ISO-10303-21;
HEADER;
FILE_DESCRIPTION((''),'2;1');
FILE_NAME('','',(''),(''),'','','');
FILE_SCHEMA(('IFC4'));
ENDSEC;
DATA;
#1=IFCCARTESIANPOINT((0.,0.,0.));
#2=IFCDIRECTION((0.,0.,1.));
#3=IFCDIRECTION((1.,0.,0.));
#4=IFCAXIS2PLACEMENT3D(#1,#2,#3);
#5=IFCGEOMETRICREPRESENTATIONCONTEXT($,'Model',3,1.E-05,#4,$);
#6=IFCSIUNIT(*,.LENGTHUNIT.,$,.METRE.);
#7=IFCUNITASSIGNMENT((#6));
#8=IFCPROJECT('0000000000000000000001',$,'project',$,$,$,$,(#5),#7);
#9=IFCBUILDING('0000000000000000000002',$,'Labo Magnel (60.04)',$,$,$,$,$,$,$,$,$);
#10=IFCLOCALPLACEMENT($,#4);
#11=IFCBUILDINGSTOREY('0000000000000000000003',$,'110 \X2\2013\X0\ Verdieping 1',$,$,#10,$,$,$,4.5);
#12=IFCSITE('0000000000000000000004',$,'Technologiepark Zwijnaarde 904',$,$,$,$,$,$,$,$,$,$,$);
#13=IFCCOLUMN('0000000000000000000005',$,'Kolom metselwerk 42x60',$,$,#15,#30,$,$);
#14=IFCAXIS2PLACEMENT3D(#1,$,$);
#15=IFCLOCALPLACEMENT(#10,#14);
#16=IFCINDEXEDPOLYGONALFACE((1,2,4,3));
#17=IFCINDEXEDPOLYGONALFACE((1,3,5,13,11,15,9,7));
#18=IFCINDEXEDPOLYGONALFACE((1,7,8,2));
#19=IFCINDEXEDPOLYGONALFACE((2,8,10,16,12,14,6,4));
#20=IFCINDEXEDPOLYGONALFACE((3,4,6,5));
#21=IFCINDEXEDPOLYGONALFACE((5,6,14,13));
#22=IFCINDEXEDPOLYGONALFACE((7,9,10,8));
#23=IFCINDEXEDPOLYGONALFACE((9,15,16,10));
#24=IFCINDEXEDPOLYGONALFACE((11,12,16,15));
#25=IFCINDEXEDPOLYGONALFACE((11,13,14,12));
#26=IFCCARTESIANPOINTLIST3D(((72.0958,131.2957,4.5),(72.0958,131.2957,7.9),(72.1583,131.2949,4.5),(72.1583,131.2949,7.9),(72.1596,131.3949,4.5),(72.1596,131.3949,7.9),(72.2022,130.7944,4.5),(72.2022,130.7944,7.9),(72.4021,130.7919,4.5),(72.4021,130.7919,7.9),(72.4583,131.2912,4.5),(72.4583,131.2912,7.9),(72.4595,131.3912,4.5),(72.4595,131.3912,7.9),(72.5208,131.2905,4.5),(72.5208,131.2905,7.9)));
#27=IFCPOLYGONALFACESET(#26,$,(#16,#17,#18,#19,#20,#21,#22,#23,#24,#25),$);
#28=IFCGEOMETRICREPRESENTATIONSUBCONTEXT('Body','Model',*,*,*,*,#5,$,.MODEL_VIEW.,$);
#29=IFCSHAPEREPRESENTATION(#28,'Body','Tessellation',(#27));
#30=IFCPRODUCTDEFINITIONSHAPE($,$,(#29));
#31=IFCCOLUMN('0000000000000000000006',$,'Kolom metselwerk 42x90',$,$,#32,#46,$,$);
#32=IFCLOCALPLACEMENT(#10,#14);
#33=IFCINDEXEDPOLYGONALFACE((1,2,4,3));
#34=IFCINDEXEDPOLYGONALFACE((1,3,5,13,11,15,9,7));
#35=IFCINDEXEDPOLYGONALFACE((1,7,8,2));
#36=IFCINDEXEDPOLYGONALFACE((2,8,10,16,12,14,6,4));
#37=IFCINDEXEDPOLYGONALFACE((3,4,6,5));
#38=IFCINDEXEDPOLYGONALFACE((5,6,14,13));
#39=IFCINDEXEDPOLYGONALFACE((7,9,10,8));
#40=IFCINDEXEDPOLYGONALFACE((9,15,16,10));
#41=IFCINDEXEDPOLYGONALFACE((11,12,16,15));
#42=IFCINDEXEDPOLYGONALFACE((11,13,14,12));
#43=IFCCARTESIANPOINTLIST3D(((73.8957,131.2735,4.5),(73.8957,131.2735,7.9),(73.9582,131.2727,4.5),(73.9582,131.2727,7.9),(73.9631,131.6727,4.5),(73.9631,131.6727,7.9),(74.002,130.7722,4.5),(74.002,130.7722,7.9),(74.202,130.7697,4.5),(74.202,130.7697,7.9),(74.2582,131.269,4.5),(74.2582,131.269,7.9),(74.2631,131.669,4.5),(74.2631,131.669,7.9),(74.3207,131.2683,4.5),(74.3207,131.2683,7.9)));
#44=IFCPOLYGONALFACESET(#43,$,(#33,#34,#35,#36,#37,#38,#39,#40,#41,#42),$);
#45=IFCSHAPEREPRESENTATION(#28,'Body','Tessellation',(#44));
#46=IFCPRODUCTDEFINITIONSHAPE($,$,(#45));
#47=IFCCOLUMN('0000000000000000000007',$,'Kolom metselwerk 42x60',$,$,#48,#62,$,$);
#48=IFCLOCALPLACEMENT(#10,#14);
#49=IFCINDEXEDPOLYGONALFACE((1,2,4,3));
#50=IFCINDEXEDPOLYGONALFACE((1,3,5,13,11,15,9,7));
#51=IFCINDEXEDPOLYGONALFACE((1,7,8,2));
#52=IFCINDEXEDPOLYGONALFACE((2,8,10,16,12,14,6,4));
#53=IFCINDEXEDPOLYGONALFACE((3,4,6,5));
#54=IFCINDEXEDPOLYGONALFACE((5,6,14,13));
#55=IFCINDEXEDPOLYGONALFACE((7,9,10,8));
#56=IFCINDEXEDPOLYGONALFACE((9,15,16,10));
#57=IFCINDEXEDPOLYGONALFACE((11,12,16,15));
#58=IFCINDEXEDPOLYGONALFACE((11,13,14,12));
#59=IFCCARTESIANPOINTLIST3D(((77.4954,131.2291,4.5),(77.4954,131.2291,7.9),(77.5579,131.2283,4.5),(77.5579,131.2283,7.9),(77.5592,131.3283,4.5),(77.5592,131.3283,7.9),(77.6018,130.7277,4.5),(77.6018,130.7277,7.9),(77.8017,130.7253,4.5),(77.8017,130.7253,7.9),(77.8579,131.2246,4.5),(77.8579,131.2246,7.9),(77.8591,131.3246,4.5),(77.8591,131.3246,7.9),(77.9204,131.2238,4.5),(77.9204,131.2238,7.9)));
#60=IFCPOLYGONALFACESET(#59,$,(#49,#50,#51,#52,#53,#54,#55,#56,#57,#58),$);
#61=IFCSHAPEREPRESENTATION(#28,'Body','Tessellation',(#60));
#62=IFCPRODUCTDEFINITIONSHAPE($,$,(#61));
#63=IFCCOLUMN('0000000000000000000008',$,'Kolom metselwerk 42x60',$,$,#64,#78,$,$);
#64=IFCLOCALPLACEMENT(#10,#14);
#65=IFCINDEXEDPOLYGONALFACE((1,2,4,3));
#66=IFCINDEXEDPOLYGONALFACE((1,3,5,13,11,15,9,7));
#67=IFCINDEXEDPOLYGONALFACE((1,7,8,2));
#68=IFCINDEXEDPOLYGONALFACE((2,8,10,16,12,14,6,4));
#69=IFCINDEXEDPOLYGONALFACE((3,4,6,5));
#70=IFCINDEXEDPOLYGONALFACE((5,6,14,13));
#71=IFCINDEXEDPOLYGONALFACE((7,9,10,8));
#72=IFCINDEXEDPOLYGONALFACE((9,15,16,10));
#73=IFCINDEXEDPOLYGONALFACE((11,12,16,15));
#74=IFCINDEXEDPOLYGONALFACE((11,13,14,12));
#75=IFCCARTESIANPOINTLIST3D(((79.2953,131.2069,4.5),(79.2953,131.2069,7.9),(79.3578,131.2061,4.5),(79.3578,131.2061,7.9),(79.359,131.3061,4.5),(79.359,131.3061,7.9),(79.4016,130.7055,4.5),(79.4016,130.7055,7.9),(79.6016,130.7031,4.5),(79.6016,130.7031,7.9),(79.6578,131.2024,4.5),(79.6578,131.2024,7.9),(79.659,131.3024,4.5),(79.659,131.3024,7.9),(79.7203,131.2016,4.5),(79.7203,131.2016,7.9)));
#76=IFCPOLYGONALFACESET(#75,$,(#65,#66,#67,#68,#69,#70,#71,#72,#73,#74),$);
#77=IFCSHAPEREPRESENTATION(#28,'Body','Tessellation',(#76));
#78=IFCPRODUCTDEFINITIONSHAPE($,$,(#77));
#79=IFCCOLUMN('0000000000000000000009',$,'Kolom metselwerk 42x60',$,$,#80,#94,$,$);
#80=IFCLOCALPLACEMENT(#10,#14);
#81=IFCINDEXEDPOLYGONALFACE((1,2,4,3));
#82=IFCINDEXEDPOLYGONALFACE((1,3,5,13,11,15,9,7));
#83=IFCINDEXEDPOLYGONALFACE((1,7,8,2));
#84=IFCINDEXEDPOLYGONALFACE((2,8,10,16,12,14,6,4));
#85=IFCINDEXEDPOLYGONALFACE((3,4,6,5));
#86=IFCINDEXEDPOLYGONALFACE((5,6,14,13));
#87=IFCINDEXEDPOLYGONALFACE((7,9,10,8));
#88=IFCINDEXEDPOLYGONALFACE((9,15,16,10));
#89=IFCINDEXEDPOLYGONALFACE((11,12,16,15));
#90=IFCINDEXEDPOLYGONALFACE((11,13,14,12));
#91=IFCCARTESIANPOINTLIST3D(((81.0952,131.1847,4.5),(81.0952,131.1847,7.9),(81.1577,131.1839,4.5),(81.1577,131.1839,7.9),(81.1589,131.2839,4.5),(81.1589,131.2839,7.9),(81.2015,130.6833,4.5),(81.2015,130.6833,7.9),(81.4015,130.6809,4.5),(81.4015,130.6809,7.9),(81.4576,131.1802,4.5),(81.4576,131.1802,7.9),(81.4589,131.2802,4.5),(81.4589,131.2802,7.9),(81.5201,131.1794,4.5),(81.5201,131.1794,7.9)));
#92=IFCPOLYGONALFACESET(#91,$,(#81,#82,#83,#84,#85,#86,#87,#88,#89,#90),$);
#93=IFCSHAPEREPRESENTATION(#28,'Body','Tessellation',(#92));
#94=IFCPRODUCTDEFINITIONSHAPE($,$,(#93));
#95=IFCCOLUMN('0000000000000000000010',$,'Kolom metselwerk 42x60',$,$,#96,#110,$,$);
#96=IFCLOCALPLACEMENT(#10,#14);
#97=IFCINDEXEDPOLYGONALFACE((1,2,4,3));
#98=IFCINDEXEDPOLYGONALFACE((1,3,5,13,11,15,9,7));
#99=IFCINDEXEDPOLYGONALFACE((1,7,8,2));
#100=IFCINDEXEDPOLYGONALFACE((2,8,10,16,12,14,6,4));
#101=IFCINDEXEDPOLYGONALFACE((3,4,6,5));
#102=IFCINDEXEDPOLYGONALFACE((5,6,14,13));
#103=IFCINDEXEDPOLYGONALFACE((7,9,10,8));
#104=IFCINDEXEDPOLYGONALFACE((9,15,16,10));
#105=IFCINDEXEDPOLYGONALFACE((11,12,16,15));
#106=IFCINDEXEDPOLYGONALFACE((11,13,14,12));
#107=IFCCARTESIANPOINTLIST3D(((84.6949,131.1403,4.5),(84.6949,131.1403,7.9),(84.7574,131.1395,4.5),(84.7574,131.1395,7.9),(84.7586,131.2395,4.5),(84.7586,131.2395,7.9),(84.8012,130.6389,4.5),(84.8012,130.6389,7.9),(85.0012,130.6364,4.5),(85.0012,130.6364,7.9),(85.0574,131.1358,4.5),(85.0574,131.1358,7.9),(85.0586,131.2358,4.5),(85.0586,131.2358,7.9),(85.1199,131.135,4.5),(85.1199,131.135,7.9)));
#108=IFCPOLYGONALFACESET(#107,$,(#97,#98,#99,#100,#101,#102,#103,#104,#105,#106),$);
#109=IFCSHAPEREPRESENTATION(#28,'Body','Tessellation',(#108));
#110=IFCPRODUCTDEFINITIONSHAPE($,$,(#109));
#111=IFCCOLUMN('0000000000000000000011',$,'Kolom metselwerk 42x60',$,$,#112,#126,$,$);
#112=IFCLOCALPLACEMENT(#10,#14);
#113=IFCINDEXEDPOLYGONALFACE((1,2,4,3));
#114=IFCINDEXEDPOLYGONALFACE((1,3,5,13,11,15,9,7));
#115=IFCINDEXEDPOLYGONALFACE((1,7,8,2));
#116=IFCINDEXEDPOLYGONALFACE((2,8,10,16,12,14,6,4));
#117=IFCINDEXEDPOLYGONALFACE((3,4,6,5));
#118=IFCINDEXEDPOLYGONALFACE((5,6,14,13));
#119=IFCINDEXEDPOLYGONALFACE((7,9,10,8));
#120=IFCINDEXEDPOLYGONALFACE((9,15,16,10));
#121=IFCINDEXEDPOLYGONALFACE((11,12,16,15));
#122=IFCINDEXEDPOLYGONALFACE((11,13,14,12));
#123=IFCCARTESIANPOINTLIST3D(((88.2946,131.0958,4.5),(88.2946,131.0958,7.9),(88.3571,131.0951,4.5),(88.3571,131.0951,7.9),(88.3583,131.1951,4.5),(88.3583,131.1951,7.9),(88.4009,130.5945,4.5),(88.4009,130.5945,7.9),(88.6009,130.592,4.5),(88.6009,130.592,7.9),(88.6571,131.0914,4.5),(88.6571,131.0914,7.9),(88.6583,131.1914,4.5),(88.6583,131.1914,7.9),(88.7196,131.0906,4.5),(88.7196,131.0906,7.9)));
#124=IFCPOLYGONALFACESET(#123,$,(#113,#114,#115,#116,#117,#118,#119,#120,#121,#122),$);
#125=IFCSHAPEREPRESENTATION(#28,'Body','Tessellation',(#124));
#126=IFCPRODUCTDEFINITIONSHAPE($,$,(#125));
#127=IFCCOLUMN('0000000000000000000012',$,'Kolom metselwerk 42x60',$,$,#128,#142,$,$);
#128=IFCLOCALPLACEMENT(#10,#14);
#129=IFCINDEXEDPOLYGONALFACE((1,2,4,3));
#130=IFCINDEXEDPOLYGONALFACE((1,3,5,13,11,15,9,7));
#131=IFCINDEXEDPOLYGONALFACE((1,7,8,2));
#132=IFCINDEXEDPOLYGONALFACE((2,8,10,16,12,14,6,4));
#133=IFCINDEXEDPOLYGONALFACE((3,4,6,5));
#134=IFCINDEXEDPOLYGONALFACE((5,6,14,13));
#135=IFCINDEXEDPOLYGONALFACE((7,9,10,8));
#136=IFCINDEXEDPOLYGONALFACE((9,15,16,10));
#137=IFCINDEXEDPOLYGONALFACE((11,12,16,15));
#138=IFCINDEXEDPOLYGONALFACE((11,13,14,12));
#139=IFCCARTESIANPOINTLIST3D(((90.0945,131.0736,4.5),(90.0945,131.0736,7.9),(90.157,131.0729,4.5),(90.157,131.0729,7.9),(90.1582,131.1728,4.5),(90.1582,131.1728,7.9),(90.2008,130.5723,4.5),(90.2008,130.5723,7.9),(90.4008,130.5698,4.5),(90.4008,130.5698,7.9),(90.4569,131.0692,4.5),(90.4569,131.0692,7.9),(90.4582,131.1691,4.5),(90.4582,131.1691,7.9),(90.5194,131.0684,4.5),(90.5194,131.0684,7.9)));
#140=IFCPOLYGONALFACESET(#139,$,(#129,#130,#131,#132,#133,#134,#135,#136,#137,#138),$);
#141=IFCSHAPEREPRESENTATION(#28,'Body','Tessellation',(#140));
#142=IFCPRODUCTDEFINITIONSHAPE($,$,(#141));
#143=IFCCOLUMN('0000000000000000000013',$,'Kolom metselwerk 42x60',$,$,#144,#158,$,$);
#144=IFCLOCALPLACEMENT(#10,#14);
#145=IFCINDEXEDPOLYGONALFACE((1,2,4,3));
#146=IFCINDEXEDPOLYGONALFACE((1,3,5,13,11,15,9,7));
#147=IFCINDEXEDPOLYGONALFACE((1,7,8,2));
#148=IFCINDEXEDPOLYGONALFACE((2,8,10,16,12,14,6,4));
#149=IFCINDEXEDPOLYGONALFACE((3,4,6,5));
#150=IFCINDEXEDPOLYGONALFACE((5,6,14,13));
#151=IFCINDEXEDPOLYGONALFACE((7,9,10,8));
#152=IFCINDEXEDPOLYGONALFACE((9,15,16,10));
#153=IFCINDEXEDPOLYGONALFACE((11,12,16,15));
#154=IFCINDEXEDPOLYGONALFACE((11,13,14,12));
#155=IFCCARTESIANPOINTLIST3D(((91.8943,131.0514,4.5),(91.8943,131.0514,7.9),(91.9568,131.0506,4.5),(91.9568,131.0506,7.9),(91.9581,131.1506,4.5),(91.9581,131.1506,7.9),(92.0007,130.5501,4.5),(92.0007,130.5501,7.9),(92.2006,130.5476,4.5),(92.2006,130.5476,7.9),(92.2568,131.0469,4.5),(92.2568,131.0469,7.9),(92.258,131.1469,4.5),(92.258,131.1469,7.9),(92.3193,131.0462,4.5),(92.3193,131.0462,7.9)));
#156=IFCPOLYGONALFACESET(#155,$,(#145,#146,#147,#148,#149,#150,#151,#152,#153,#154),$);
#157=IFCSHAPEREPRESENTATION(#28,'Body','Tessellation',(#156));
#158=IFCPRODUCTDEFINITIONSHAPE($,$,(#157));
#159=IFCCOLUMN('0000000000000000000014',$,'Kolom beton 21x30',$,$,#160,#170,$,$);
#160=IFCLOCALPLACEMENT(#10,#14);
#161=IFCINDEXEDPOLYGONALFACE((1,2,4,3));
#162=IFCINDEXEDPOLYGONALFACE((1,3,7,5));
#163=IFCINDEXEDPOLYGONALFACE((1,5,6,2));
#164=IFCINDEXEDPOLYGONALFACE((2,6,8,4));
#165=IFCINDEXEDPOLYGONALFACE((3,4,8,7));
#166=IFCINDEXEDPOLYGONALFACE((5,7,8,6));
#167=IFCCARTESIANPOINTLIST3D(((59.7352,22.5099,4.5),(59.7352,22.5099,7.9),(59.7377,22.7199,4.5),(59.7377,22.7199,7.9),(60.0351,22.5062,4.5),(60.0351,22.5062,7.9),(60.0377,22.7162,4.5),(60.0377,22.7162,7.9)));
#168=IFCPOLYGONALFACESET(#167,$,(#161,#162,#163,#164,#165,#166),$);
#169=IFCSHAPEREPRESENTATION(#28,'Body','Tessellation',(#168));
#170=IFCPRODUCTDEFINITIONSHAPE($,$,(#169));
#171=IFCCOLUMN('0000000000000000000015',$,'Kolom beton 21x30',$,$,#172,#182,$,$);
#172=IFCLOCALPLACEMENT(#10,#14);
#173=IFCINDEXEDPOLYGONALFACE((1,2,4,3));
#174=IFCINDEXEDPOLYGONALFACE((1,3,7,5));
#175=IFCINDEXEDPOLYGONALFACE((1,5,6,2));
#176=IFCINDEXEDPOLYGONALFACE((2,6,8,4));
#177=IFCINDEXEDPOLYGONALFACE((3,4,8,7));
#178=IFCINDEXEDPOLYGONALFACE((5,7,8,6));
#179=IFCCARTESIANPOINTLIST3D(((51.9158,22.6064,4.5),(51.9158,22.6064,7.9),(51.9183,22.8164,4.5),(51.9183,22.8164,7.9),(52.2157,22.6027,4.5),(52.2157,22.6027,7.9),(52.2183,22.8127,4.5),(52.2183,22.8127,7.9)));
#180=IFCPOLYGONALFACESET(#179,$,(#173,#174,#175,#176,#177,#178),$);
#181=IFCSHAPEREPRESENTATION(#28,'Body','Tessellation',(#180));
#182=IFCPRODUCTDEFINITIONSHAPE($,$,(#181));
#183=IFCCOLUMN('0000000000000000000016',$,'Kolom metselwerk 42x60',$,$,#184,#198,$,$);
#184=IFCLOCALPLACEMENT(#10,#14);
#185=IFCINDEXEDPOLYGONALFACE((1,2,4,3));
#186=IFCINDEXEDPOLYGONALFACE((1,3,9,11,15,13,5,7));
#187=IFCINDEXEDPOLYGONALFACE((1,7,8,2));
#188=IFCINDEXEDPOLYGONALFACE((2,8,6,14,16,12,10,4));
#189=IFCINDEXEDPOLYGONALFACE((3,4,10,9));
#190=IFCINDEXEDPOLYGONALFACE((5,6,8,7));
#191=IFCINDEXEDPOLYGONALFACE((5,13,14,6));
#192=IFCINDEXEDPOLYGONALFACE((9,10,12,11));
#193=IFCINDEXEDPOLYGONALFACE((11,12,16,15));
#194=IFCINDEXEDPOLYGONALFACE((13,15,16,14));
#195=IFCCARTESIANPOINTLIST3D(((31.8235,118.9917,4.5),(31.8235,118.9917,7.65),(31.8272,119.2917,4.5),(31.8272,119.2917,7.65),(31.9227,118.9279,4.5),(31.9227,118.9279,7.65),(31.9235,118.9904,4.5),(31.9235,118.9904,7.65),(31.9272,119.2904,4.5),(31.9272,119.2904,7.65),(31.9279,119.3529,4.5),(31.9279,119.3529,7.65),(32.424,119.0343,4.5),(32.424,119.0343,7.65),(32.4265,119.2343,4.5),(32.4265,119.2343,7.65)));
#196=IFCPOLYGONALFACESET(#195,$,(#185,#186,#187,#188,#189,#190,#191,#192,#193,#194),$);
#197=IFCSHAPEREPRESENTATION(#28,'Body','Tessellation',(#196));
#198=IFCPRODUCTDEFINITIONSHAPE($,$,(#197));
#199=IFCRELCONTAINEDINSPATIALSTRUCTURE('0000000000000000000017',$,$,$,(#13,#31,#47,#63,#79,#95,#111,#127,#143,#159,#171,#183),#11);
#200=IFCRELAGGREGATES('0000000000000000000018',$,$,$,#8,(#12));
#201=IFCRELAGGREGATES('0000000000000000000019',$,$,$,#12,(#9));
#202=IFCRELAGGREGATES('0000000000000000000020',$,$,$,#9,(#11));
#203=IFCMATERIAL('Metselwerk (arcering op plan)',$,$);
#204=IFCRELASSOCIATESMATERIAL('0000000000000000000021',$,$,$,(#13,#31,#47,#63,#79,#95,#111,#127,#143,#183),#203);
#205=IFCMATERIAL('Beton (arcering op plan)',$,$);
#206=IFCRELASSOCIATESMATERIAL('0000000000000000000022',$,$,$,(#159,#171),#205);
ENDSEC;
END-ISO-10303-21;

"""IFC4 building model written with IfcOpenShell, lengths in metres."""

from ifc_helpers import new_model, si_unit, frame, origin, origin_with_axes, place, context, subcontext, project, spatial, polyline, outline, extrude, material, element, save


model = new_model("IFC4")

# Units and contexts
model_context = context("Model", 3, precision=1e-05, world=origin_with_axes())
body_context = subcontext(model_context, "Body", "Model", "MODEL_VIEW")
ifc_project = project(units=[si_unit("LENGTHUNIT", "METRE")], contexts=[model_context])

# Site, building, storey
site = spatial("IfcSite", under=ifc_project, Name="Technologiepark Zwijnaarde 904")
building = spatial("IfcBuilding", under=site, Name="Labo Magnel (60.04)")
storey_placement = place(None, origin_with_axes())
storey = spatial("IfcBuildingStorey", under=building, at=storey_placement, Name="110 – Verdieping 1", Elevation=4.5)

# Columns
ifc_material_1 = material(Name="Metselwerk (arcering op plan)")
column_1_placement = place(storey_placement, frame((0.0, 0.0, 4.5), z_axis=(0.0, 0.0, 1.0), x_axis=(1.0, 0.0, 0.0)))
element("IfcColumn", 1, at=column_1_placement, inside=storey, material=ifc_material_1, Name="Kolom metselwerk 42x60", context=body_context, shape_type="SweptSolid", body=[
    extrude(outline(polyline([(72.5208, 131.2905), (72.4583, 131.2912), (72.4595, 131.3912), (72.1596, 131.3949), (72.1583, 131.2949), (72.0958, 131.2957), (72.2022, 130.7944), (72.4021, 130.7919), (72.5208, 131.2905)])), origin(), (0.0, 0.0, 1.0), 3.4),
])
column_2_placement = place(storey_placement, frame((0.0, 0.0, 4.5), z_axis=(0.0, 0.0, 1.0), x_axis=(1.0, 0.0, 0.0)))
element("IfcColumn", 2, at=column_2_placement, inside=storey, material=ifc_material_1, Name="Kolom metselwerk 42x90", context=body_context, shape_type="SweptSolid", body=[
    extrude(outline(polyline([(74.3207, 131.2683), (74.2582, 131.269), (74.2631, 131.669), (73.9631, 131.6727), (73.9582, 131.2727), (73.8957, 131.2735), (74.002, 130.7722), (74.202, 130.7697), (74.3207, 131.2683)])), origin(), (0.0, 0.0, 1.0), 3.4),
])
column_3_placement = place(storey_placement, frame((0.0, 0.0, 4.5), z_axis=(0.0, 0.0, 1.0), x_axis=(1.0, 0.0, 0.0)))
element("IfcColumn", 3, at=column_3_placement, inside=storey, material=ifc_material_1, Name="Kolom metselwerk 42x60", context=body_context, shape_type="SweptSolid", body=[
    extrude(outline(polyline([(77.9204, 131.2238), (77.8579, 131.2246), (77.8591, 131.3246), (77.5592, 131.3283), (77.5579, 131.2283), (77.4954, 131.2291), (77.6018, 130.7277), (77.8017, 130.7253), (77.9204, 131.2238)])), origin(), (0.0, 0.0, 1.0), 3.4),
])
column_4_placement = place(storey_placement, frame((0.0, 0.0, 4.5), z_axis=(0.0, 0.0, 1.0), x_axis=(1.0, 0.0, 0.0)))
element("IfcColumn", 4, at=column_4_placement, inside=storey, material=ifc_material_1, Name="Kolom metselwerk 42x60", context=body_context, shape_type="SweptSolid", body=[
    extrude(outline(polyline([(79.7203, 131.2016), (79.6578, 131.2024), (79.659, 131.3024), (79.359, 131.3061), (79.3578, 131.2061), (79.2953, 131.2069), (79.4016, 130.7055), (79.6016, 130.7031), (79.7203, 131.2016)])), origin(), (0.0, 0.0, 1.0), 3.4),
])
column_5_placement = place(storey_placement, frame((0.0, 0.0, 4.5), z_axis=(0.0, 0.0, 1.0), x_axis=(1.0, 0.0, 0.0)))
element("IfcColumn", 5, at=column_5_placement, inside=storey, material=ifc_material_1, Name="Kolom metselwerk 42x60", context=body_context, shape_type="SweptSolid", body=[
    extrude(outline(polyline([(81.5201, 131.1794), (81.4576, 131.1802), (81.4589, 131.2802), (81.1589, 131.2839), (81.1577, 131.1839), (81.0952, 131.1847), (81.2015, 130.6833), (81.4015, 130.6809), (81.5201, 131.1794)])), origin(), (0.0, 0.0, 1.0), 3.4),
])
column_6_placement = place(storey_placement, frame((0.0, 0.0, 4.5), z_axis=(0.0, 0.0, 1.0), x_axis=(1.0, 0.0, 0.0)))
element("IfcColumn", 6, at=column_6_placement, inside=storey, material=ifc_material_1, Name="Kolom metselwerk 42x60", context=body_context, shape_type="SweptSolid", body=[
    extrude(outline(polyline([(85.1199, 131.135), (85.0574, 131.1358), (85.0586, 131.2358), (84.7586, 131.2395), (84.7574, 131.1395), (84.6949, 131.1403), (84.8012, 130.6389), (85.0012, 130.6364), (85.1199, 131.135)])), origin(), (0.0, 0.0, 1.0), 3.4),
])
column_7_placement = place(storey_placement, frame((0.0, 0.0, 4.5), z_axis=(0.0, 0.0, 1.0), x_axis=(1.0, 0.0, 0.0)))
element("IfcColumn", 7, at=column_7_placement, inside=storey, material=ifc_material_1, Name="Kolom metselwerk 42x60", context=body_context, shape_type="SweptSolid", body=[
    extrude(outline(polyline([(88.7196, 131.0906), (88.6571, 131.0914), (88.6583, 131.1914), (88.3583, 131.1951), (88.3571, 131.0951), (88.2946, 131.0958), (88.4009, 130.5945), (88.6009, 130.592), (88.7196, 131.0906)])), origin(), (0.0, 0.0, 1.0), 3.4),
])
column_8_placement = place(storey_placement, frame((0.0, 0.0, 4.5), z_axis=(0.0, 0.0, 1.0), x_axis=(1.0, 0.0, 0.0)))
element("IfcColumn", 8, at=column_8_placement, inside=storey, material=ifc_material_1, Name="Kolom metselwerk 42x60", context=body_context, shape_type="SweptSolid", body=[
    extrude(outline(polyline([(90.5194, 131.0684), (90.4569, 131.0692), (90.4582, 131.1691), (90.1582, 131.1728), (90.157, 131.0729), (90.0945, 131.0736), (90.2008, 130.5723), (90.4008, 130.5698), (90.5194, 131.0684)])), origin(), (0.0, 0.0, 1.0), 3.4),
])
column_9_placement = place(storey_placement, frame((0.0, 0.0, 4.5), z_axis=(0.0, 0.0, 1.0), x_axis=(1.0, 0.0, 0.0)))
element("IfcColumn", 9, at=column_9_placement, inside=storey, material=ifc_material_1, Name="Kolom metselwerk 42x60", context=body_context, shape_type="SweptSolid", body=[
    extrude(outline(polyline([(92.3193, 131.0462), (92.2568, 131.0469), (92.258, 131.1469), (91.9581, 131.1506), (91.9568, 131.0506), (91.8943, 131.0514), (92.0007, 130.5501), (92.2006, 130.5476), (92.3193, 131.0462)])), origin(), (0.0, 0.0, 1.0), 3.4),
])
ifc_material_2 = material(Name="Beton (arcering op plan)")
column_10_placement = place(storey_placement, frame((0.0, 0.0, 4.5), z_axis=(0.0, 0.0, 1.0), x_axis=(1.0, 0.0, 0.0)))
element("IfcColumn", 10, at=column_10_placement, inside=storey, material=ifc_material_2, Name="Kolom beton 21x30", context=body_context, shape_type="SweptSolid", body=[
    extrude(outline(polyline([(60.0377, 22.7162), (59.7377, 22.7199), (59.7352, 22.5099), (60.0351, 22.5062), (60.0377, 22.7162)])), origin(), (0.0, 0.0, 1.0), 3.4),
])
column_11_placement = place(storey_placement, frame((0.0, 0.0, 4.5), z_axis=(0.0, 0.0, 1.0), x_axis=(1.0, 0.0, 0.0)))
element("IfcColumn", 11, at=column_11_placement, inside=storey, material=ifc_material_2, Name="Kolom beton 21x30", context=body_context, shape_type="SweptSolid", body=[
    extrude(outline(polyline([(52.2183, 22.8127), (51.9183, 22.8164), (51.9158, 22.6064), (52.2157, 22.6027), (52.2183, 22.8127)])), origin(), (0.0, 0.0, 1.0), 3.4),
])
column_12_placement = place(storey_placement, frame((0.0, 0.0, 4.5), z_axis=(0.0, 0.0, 1.0), x_axis=(1.0, 0.0, 0.0)))
element("IfcColumn", 12, at=column_12_placement, inside=storey, material=ifc_material_1, Name="Kolom metselwerk 42x60", context=body_context, shape_type="SweptSolid", body=[
    extrude(outline(polyline([(32.424, 119.0343), (32.4265, 119.2343), (31.9279, 119.3529), (31.9272, 119.2904), (31.8272, 119.2917), (31.8235, 118.9917), (31.9235, 118.9904), (31.9227, 118.9279), (32.424, 119.0343)])), origin(), (0.0, 0.0, 1.0), 3.15),
])

save(model, "model.ifc")
